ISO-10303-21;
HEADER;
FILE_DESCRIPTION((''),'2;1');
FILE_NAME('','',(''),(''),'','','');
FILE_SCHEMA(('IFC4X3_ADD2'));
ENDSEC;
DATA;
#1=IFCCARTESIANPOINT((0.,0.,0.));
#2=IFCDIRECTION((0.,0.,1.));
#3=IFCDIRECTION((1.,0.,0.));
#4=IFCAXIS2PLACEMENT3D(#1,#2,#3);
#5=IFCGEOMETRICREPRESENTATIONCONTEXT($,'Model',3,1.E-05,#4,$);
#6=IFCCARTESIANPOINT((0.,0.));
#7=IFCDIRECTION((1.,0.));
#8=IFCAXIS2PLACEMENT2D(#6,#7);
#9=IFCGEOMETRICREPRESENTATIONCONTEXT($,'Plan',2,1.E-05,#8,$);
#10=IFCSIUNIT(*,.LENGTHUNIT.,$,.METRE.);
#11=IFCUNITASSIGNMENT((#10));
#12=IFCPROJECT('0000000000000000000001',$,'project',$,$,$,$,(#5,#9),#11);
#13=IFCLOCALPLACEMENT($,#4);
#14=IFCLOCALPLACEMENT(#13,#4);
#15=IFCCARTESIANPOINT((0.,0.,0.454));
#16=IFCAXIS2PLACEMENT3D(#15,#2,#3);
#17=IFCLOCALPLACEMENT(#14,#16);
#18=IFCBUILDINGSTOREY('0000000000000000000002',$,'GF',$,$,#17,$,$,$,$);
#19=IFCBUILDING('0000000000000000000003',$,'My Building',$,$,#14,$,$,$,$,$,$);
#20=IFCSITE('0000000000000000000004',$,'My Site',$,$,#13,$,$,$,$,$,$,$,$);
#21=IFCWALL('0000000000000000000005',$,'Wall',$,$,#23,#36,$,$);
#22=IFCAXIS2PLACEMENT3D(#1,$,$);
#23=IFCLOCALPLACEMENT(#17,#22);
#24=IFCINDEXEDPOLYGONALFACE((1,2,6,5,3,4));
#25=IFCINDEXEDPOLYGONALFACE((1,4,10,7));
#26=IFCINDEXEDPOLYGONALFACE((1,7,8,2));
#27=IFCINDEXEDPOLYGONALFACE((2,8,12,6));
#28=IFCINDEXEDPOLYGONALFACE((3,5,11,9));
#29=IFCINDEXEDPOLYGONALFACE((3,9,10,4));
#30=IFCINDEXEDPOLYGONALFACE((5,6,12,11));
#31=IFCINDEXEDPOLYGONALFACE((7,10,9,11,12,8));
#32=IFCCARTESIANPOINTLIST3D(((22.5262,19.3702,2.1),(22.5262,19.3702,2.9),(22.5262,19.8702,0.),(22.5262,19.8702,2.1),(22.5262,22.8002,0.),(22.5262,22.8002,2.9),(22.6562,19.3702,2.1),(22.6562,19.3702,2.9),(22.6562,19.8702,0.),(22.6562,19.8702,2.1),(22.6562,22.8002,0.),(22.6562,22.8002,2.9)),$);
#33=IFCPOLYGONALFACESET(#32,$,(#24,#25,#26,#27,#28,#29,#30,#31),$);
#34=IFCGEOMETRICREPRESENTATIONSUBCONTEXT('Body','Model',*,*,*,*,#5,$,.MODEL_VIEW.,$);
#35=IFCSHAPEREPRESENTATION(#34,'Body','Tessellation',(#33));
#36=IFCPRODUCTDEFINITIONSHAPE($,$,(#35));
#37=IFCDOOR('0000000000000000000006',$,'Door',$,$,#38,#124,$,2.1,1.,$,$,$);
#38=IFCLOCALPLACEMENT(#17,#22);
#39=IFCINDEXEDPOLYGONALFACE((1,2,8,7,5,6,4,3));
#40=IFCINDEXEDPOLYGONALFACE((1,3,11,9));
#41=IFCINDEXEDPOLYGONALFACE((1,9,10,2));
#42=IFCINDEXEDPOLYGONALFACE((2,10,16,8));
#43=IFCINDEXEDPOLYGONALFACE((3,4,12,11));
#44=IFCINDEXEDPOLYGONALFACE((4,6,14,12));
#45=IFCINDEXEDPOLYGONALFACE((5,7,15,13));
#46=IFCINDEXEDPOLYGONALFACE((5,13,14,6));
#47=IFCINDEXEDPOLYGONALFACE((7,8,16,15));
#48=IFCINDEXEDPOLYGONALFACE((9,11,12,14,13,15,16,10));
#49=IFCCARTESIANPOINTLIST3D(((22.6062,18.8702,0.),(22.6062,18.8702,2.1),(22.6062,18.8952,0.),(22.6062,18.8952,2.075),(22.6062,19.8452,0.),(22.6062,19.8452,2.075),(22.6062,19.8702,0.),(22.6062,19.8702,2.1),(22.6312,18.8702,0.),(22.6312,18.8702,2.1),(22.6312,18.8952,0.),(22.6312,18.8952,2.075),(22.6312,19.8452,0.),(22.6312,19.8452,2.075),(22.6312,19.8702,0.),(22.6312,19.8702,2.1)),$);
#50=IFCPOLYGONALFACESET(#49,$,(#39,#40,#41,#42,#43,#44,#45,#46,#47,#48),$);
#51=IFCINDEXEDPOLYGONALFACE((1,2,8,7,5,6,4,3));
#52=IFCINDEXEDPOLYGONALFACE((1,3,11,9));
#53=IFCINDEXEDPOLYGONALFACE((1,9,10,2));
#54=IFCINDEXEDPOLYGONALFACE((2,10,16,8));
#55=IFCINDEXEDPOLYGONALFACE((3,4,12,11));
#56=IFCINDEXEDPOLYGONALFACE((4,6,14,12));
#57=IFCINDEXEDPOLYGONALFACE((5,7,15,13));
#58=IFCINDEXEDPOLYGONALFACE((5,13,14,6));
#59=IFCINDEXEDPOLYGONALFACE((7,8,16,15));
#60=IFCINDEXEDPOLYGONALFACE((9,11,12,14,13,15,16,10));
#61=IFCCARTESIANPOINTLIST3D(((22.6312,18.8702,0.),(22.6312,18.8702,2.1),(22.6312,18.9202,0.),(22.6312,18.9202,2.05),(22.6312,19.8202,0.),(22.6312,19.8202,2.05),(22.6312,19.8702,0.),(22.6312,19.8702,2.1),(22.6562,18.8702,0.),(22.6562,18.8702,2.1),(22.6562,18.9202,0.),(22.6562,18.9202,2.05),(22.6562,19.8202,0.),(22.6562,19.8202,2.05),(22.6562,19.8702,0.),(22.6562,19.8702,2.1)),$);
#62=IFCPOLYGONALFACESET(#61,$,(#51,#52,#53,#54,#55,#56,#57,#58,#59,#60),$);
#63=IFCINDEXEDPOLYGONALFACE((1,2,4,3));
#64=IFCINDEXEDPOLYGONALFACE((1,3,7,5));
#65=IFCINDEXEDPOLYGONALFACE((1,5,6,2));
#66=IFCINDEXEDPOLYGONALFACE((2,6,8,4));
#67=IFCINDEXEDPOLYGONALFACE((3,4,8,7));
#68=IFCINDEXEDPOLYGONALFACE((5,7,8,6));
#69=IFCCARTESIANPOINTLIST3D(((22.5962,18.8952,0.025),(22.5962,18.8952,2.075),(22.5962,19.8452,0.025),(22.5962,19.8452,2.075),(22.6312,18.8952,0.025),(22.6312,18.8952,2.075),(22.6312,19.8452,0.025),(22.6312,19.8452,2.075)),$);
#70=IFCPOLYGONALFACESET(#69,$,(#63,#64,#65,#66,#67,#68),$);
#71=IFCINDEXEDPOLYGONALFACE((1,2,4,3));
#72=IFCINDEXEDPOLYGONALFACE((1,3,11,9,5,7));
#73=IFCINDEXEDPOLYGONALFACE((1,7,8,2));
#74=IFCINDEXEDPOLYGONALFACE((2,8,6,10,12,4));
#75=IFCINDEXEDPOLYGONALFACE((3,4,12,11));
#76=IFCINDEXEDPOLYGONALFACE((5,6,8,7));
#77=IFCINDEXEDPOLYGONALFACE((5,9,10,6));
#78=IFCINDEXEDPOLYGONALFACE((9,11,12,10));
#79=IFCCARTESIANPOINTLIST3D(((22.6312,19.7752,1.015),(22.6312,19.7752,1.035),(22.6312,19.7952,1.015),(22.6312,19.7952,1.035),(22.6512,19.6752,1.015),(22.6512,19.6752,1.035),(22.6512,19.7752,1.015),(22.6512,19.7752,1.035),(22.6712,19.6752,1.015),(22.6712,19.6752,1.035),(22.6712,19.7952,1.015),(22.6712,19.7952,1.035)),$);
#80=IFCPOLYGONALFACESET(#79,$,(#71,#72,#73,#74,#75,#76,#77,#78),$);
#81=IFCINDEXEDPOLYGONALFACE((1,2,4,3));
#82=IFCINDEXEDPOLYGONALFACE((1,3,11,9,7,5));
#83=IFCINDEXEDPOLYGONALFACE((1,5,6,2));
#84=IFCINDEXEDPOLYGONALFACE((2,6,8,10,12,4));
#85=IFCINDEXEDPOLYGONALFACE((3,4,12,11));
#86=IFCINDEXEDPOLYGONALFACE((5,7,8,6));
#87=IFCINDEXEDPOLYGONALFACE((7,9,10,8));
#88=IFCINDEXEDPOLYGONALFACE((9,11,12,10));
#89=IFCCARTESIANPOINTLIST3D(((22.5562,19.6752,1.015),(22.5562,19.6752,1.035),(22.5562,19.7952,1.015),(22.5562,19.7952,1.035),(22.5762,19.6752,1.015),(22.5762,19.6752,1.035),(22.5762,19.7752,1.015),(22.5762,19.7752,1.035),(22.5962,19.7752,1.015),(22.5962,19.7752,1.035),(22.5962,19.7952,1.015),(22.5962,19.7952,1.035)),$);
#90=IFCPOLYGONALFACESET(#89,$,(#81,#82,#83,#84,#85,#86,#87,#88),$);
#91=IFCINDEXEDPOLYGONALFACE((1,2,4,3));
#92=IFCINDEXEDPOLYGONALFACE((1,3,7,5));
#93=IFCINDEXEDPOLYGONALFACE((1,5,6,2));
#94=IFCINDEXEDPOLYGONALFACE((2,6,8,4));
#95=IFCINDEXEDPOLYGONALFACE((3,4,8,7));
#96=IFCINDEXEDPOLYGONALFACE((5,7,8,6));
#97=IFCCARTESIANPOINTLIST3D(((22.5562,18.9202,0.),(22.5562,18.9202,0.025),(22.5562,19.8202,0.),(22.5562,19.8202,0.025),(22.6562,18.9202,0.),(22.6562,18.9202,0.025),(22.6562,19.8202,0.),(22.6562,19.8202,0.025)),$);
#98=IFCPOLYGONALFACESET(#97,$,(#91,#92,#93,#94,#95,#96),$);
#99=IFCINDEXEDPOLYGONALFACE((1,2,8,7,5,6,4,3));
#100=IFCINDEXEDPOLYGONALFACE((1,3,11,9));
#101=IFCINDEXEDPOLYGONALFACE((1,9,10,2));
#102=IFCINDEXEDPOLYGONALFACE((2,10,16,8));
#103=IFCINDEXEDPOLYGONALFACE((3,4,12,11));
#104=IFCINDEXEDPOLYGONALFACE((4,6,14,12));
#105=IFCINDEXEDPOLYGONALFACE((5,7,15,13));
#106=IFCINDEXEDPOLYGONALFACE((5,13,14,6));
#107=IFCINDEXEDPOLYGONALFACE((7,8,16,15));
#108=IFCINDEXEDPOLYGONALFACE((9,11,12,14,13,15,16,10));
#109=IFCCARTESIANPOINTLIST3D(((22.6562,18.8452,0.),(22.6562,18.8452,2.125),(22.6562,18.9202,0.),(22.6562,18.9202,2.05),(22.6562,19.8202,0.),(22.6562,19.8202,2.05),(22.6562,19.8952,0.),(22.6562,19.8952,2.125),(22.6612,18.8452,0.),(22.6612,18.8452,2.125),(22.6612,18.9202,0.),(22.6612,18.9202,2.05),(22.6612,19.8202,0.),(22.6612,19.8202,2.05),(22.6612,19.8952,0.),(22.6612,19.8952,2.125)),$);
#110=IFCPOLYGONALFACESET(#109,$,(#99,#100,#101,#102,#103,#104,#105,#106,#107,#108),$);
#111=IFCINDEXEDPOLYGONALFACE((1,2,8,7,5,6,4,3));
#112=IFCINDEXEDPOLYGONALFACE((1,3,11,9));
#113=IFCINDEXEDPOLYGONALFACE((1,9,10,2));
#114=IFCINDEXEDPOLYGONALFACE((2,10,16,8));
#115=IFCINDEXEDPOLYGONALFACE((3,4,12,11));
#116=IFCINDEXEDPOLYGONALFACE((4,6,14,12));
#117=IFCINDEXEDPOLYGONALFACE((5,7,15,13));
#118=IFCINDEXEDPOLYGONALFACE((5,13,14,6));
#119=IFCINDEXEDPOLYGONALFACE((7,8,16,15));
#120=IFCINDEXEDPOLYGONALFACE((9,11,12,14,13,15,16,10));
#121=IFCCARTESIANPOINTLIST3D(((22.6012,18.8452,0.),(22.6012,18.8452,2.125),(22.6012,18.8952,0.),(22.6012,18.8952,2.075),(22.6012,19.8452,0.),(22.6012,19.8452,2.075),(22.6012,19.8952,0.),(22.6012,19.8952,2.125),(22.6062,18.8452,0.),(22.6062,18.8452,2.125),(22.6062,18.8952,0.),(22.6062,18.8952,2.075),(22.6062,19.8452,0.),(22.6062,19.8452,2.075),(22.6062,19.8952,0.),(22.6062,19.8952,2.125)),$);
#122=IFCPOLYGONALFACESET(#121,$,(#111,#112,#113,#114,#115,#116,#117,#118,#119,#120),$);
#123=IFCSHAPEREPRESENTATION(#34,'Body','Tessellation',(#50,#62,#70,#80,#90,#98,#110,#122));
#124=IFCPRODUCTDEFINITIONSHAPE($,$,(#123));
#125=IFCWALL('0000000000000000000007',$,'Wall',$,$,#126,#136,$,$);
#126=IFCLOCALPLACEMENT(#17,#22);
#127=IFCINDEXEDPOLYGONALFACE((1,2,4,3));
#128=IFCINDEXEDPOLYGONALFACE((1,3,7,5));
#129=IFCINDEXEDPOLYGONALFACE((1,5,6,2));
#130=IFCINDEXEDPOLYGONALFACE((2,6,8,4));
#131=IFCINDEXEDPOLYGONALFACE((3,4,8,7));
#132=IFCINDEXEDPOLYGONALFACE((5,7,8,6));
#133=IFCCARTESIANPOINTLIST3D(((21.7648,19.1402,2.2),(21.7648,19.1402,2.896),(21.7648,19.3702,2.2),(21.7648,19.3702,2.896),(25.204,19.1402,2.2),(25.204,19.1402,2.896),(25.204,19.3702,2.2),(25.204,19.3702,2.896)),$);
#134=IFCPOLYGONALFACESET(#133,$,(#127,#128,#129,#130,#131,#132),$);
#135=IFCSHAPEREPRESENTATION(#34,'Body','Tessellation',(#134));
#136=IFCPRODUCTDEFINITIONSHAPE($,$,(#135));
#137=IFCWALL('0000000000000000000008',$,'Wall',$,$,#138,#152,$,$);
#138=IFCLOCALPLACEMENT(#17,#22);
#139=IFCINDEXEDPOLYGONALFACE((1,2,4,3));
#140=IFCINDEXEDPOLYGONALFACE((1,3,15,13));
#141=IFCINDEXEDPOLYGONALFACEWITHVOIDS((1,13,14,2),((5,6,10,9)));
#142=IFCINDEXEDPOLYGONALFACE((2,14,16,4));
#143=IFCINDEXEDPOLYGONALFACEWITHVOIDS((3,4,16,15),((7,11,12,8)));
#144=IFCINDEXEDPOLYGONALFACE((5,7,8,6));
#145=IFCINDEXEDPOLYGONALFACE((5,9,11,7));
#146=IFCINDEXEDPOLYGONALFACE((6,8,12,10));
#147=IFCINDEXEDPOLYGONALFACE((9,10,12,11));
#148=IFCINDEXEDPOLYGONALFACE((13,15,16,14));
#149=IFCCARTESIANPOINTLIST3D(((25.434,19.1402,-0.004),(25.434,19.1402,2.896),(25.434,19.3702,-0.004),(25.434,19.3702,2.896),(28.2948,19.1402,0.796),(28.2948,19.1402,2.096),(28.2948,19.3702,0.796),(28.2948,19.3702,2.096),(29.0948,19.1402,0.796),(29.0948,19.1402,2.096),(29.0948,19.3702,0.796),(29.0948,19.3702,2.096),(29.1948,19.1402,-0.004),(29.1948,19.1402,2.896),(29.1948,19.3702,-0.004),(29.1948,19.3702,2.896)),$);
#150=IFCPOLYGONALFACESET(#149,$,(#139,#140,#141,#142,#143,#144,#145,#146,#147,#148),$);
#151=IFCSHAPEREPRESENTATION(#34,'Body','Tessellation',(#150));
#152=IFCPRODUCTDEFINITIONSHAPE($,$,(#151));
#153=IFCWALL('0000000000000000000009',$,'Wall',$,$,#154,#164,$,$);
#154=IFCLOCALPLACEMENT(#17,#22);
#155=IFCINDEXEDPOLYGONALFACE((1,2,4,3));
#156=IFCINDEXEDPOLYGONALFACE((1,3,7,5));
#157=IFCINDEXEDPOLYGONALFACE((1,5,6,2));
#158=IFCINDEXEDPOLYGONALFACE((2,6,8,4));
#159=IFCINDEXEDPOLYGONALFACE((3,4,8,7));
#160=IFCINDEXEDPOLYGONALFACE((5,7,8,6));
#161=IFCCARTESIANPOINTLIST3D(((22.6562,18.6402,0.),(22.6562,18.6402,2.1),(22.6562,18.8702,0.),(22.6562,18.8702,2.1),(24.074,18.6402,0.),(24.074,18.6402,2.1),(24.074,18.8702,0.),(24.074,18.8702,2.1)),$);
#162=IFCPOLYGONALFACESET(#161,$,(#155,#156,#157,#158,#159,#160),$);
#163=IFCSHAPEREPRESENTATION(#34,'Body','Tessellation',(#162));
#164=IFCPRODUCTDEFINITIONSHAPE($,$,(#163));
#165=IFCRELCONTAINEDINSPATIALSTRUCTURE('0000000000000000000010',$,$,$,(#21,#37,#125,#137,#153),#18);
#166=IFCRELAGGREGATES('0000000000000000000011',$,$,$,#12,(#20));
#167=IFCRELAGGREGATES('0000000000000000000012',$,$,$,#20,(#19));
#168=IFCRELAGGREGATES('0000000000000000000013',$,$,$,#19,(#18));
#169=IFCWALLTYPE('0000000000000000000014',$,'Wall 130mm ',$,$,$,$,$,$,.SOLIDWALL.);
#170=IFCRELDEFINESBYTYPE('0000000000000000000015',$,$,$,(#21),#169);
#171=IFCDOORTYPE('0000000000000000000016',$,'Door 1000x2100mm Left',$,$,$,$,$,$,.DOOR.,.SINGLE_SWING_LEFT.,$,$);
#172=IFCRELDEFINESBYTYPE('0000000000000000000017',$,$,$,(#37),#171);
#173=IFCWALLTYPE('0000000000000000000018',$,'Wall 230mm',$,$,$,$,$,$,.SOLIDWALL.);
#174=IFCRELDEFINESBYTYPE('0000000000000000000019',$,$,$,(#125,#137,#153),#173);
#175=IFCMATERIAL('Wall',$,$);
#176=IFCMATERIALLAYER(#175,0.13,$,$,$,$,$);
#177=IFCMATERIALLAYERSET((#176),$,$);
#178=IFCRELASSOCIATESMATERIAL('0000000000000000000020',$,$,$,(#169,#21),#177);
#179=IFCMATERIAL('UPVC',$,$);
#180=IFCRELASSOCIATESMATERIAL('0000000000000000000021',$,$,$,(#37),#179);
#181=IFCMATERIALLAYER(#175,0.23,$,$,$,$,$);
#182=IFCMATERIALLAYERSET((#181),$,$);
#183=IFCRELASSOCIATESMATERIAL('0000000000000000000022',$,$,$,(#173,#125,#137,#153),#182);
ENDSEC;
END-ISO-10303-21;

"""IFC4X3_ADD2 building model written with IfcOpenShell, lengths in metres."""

from ifc_helpers import new_model, entity, si_unit, frame, origin_with_axes, origin_2d_with_axis, place, context, subcontext, project, spatial, line, indexed_curve, outline, extrude, clip, halfspace, shape, source, transform, mapped, material, layer, layer_set, layer_usage, type_object, type_shapes, element, fill, save


model = new_model("IFC4X3_ADD2")

# Units and contexts
model_context = context("Model", 3, precision=1e-05, world=origin_with_axes())
plan_context = context("Plan", 2, precision=1e-05, world=origin_2d_with_axis())
body_context_1 = subcontext(model_context, "Body", "Model", "MODEL_VIEW")
body_context_2 = subcontext(plan_context, "Body", "Plan", "PLAN_VIEW")
ifc_project = project(units=[si_unit("LENGTHUNIT", "METRE")], contexts=[model_context, plan_context])

# Site, building, storey
site_placement = place(None, origin_with_axes())
site = spatial("IfcSite", under=ifc_project, at=site_placement, Name="My Site")
building_placement = place(site_placement, origin_with_axes())
building = spatial("IfcBuilding", under=site, at=building_placement, Name="My Building")
storey_placement = place(building_placement, frame((0.0, 0.0, 0.454), z_axis=(0.0, 0.0, 1.0), x_axis=(1.0, 0.0, 0.0)))
storey = spatial("IfcBuildingStorey", under=building, at=storey_placement, Name="GF")

# Shared definitions
ifc_material_1 = material(Name="Wall")
ifc_layer_1 = layer(ifc_material_1, 0.13)
ifc_layer_set_1 = layer_set([ifc_layer_1])
wall_type_1 = type_object("IfcWallType", Name="Wall 130mm ", PredefinedType="SOLIDWALL", material=ifc_layer_set_1)
ifc_material_2 = material(Name="UPVC")

# Wall, opening, door
ifc_layer_usage_1 = layer_usage(ifc_layer_set_1, "AXIS2", "POSITIVE", 0.0)
wall_1_placement = place(storey_placement, frame((22.6562, 19.3702, 0.0), z_axis=(0.0, 0.0, 1.0), x_axis=(0.000002, 1.0, 0.0)))
wall_1 = element("IfcWall", 1, at=wall_1_placement, inside=storey, type_object=wall_type_1, material=ifc_layer_usage_1, Name="Wall", context=body_context_1, shape_type="SweptSolid", body=[
    extrude(outline(indexed_curve([(0.0, 0.0), (0.0, 0.13), (3.43, 0.13), (3.43, 0.0), (0.0, 0.0)], self_intersect=False)), origin_with_axes(), (0.0, 0.0, 1.0), 2.9),
])
shared_shape_1 = source(origin_with_axes(), body_context_1, "Body", "SweptSolid", [
    extrude(outline(indexed_curve([(0.0, 0.0), (1.0, 0.0), (1.0, 2.1), (0.0, 2.1)], segments=[line(1, 2, 3, 4, 1)])), frame((0.0, -0.6, 0.0), z_axis=(0.0, -1.0, 0.0), x_axis=(1.0, 0.0, 0.0)), (0.0, 0.0, -1.0), 1.2),
])
opening_1_placement = place(wall_1_placement, frame((-0.5, 0.0, 0.0), z_axis=(0.0, 0.0, 1.0), x_axis=(1.0, 0.0, 0.0)))
opening_1 = element("IfcOpeningElement", 2, at=opening_1_placement, cuts=wall_1, PredefinedType="OPENING", context=body_context_1, shape_type="MappedRepresentation", body=[
    mapped(shared_shape_1, transform((0.0, 0.0, 0.0), x_axis=(1.0, 0.0, 0.0), y_axis=(0.0, 1.0, 0.0), z_axis=(0.0, 0.0, 1.0), scale=1.0)),
])
door_type_1 = type_object("IfcDoorType", Name="Door 1000x2100mm Left", OperationType="SINGLE_SWING_LEFT", PredefinedType="DOOR")
shared_shape_2 = source(origin_with_axes(), body_context_1, "Body", "SweptSolid", [
    extrude(outline(indexed_curve([(0.0, 0.0), (0.0, 2.1), (1.0, 2.1), (1.0, 0.0), (0.975, 0.0), (0.975, 2.075), (0.025, 2.075), (0.025, 0.0)], segments=[line(1, 2, 3, 4, 5, 6, 7, 8, 1)])), frame((0.0, 0.025, 0.0), z_axis=(0.0, -1.0, 0.0), x_axis=(1.0, 0.0, 0.0)), (0.0, 0.0, -1.0), 0.025),
    extrude(outline(indexed_curve([(0.0, 0.0), (0.0, 2.1), (1.0, 2.1), (1.0, 0.0), (0.95, 0.0), (0.95, 2.05), (0.05, 2.05), (0.05, 0.0)], segments=[line(1, 2, 3, 4, 5, 6, 7, 8, 1)])), frame((0.0, 0.0, 0.0), z_axis=(0.0, -1.0, 0.0), x_axis=(1.0, 0.0, 0.0)), (0.0, 0.0, -1.0), 0.025),
    extrude(outline(indexed_curve([(0.0, 0.0), (0.95, 0.0), (0.95, 0.035), (0.0, 0.035)], segments=[line(1, 2, 3, 4, 1)])), frame((0.025, 0.025, 0.025), z_axis=(0.0, 0.0, 1.0), x_axis=(1.0, 0.0, 0.0)), (0.0, 0.0, 1.0), 2.05),
    extrude(outline(indexed_curve([(0.0, 0.0), (0.0, -0.04), (-0.12, -0.04), (-0.12, -0.02), (-0.02, -0.02), (-0.02, 0.0)], segments=[line(1, 2, 3, 4, 5, 6, 1)])), frame((0.925, 0.025, 1.015), z_axis=(0.0, 0.0, 1.0), x_axis=(1.0, 0.0, 0.0)), (0.0, 0.0, 1.0), 0.02),
    extrude(outline(indexed_curve([(0.0, 0.0), (0.0, 0.04), (-0.12, 0.04), (-0.12, 0.02), (-0.02, 0.02), (-0.02, 0.0)], segments=[line(1, 2, 3, 4, 5, 6, 1)])), frame((0.925, 0.06, 1.015), z_axis=(0.0, 0.0, 1.0), x_axis=(1.0, 0.0, 0.0)), (0.0, 0.0, 1.0), 0.02),
    extrude(outline(indexed_curve([(0.0, 0.0), (0.9, 0.0), (0.9, 0.1), (0.0, 0.1)], segments=[line(1, 2, 3, 4, 1)])), frame((0.05, 0.0, 0.0), z_axis=(0.0, 0.0, 1.0), x_axis=(1.0, 0.0, 0.0)), (0.0, 0.0, 1.0), 0.025),
    extrude(outline(indexed_curve([(0.0, 0.0), (0.0, 2.125), (1.05, 2.125), (1.05, 0.0), (0.975, 0.0), (0.975, 2.05), (0.075, 2.05), (0.075, 0.0)], segments=[line(1, 2, 3, 4, 5, 6, 7, 8, 1)])), frame((-0.025, -0.005, 0.0), z_axis=(0.0, -1.0, 0.0), x_axis=(1.0, 0.0, 0.0)), (0.0, 0.0, -1.0), 0.005),
    extrude(outline(indexed_curve([(0.0, 0.0), (0.0, 2.125), (1.05, 2.125), (1.05, 0.0), (1.0, 0.0), (1.0, 2.075), (0.05, 2.075), (0.05, 0.0)], segments=[line(1, 2, 3, 4, 5, 6, 7, 8, 1)])), frame((-0.025, 0.05, 0.0), z_axis=(0.0, -1.0, 0.0), x_axis=(1.0, 0.0, 0.0)), (0.0, 0.0, -1.0), 0.005),
])
shared_shape_3 = source(origin_with_axes(), body_context_2, "Body", "Curve2D", [
    entity("IfcIndexedPolyCurve", entity("IfcCartesianPointList2D", [[0.0, 0.0], [0.0, 0.05], [0.025, 0.05], [0.025, 0.025], [0.05, 0.025], [0.05, 0.0]]), [entity("IfcLineIndex", [1, 2, 3, 4, 5, 6, 1])]),
    entity("IfcIndexedPolyCurve", entity("IfcCartesianPointList2D", [[1.0, 0.0], [1.0, 0.05], [0.975, 0.05], [0.975, 0.025], [0.95, 0.025], [0.95, 0.0]]), [entity("IfcLineIndex", [1, 2, 3, 4, 5, 6, 1])]),
    entity("IfcTrimmedCurve", entity("IfcEllipse", entity("IfcAxis2Placement2D", entity("IfcCartesianPoint", [0.06, 0.05]), entity("IfcDirection", [1.0, 0.0])), 0.915, 0.95), [entity("IfcCartesianPoint", [0.975, 0.05])], [entity("IfcCartesianPoint", [0.06, 1.0])], True, "CARTESIAN"),
    entity("IfcIndexedPolyCurve", entity("IfcCartesianPointList2D", [[0.025, 0.05], [0.06, 0.05], [0.06, 1.0], [0.025, 1.0]]), [entity("IfcLineIndex", [1, 2, 3, 4, 1])]),
])
type_shapes(door_type_1, [shared_shape_2, shared_shape_3])
door_1_placement = place(opening_1_placement, frame((0.0, 0.0, 0.0), z_axis=(0.0, 0.0, 1.0), x_axis=(1.0, 0.0, 0.0)))
door_1 = element("IfcDoor", 3, at=door_1_placement, inside=storey, type_object=door_type_1, material=ifc_material_2, Name="Door", OverallHeight=2.1, OverallWidth=1.0, shapes=[
    shape(body_context_1, "Body", "MappedRepresentation", [mapped(shared_shape_2, transform((0.0, 0.0, 0.0), x_axis=(1.0, 0.0, 0.0), y_axis=(0.0, 1.0, 0.0), z_axis=(0.0, 0.0, 1.0), scale=1.0))]),
    shape(body_context_2, "Body", "MappedRepresentation", [mapped(shared_shape_3, transform((0.0, 0.0, 0.0), x_axis=(1.0, 0.0, 0.0), y_axis=(0.0, 1.0, 0.0), z_axis=(0.0, 0.0, 1.0), scale=1.0))]),
])
fill(opening_1, door_1)

# Shared definitions
ifc_layer_2 = layer(ifc_material_1, 0.23)
ifc_layer_set_2 = layer_set([ifc_layer_2])
wall_type_2 = type_object("IfcWallType", Name="Wall 230mm", PredefinedType="SOLIDWALL", material=ifc_layer_set_2)
shared_shape_4 = source(origin_with_axes(), body_context_1, "Body", "SweptSolid", [
    extrude(outline(indexed_curve([(0.0, 0.0), (0.8, 0.0), (0.8, 1.3), (0.0, 1.3)], segments=[line(1, 2, 3, 4, 1)])), frame((-0.4, -0.6, 0.0), z_axis=(0.0, -1.0, 0.0), x_axis=(1.0, 0.0, 0.0)), (0.0, 0.0, -1.0), 1.2),
])

# Wall
ifc_layer_usage_2 = layer_usage(ifc_layer_set_2, "AXIS2", "POSITIVE", 0.0)
wall_2_placement = place(storey_placement, frame((25.204, 19.3702, 2.2), z_axis=(0.0, 0.0, 1.0), x_axis=(-1.0, 0.0, 0.0)))
element("IfcWall", 4, at=wall_2_placement, inside=storey, type_object=wall_type_2, material=ifc_layer_usage_2, Name="Wall", context=body_context_1, shape_type="Clipping", body=[
    clip(clip(extrude(outline(indexed_curve([(0.0, 0.0), (0.0, 0.23), (3.4392, 0.23), (3.4392, 0.0), (0.0, 0.0)], self_intersect=False)), origin_with_axes(), (0.0, 0.0, 1.0), 6.25), halfspace(frame((0.0, 0.0, 3.596), z_axis=(0.0, 0.0, 1.0), x_axis=(-1.0, 0.0, 0.0)), False)), halfspace(frame((0.0, 0.0, 0.696), z_axis=(0.0, 0.0, 1.0), x_axis=(-1.0, 0.0, 0.0)), False)),
])

# Wall, opening
ifc_layer_usage_3 = layer_usage(ifc_layer_set_2, "AXIS2", "POSITIVE", 0.0)
wall_3_placement = place(storey_placement, frame((29.1948, 19.3702, -0.004), z_axis=(0.0, 0.0, 1.0), x_axis=(-1.0, 0.0, 0.0)))
wall_3 = element("IfcWall", 5, at=wall_3_placement, inside=storey, type_object=wall_type_2, material=ifc_layer_usage_3, Name="Wall", context=body_context_1, shape_type="SweptSolid", body=[
    extrude(outline(indexed_curve([(0.0, 0.0), (0.0, 0.23), (3.7608, 0.23), (3.7608, 0.0), (0.0, 0.0)], self_intersect=False)), origin_with_axes(), (0.0, 0.0, 1.0), 2.9),
])
opening_2_placement = place(wall_3_placement, frame((0.5, 0.16, 0.8), z_axis=(0.0, 0.0, 1.0), x_axis=(1.0, 0.0, 0.0)))
element("IfcOpeningElement", 6, at=opening_2_placement, cuts=wall_3, PredefinedType="OPENING", context=body_context_1, shape_type="MappedRepresentation", body=[
    mapped(shared_shape_4, transform((0.0, 0.0, 0.0), x_axis=(1.0, 0.0, 0.0), y_axis=(0.0, 1.0, 0.0), z_axis=(0.0, 0.0, 1.0), scale=1.0)),
])

# Wall
ifc_layer_usage_4 = layer_usage(ifc_layer_set_2, "AXIS2", "POSITIVE", 0.0)
wall_4_placement = place(storey_placement, frame((24.074, 18.8702, 0.0), z_axis=(0.0, 0.0, 1.0), x_axis=(-1.0, 0.0, 0.0)))
element("IfcWall", 7, at=wall_4_placement, inside=storey, type_object=wall_type_2, material=ifc_layer_usage_4, Name="Wall", context=body_context_1, shape_type="Clipping", body=[
    clip(extrude(outline(indexed_curve([(0.0, 0.0), (0.0, 0.23), (1.4178, 0.23), (1.4178, 0.0), (0.0, 0.0)], self_intersect=False)), origin_with_axes(), (0.0, 0.0, 1.0), 2.554), halfspace(frame((0.0, 0.0, 2.1), z_axis=(0.0, 0.0, 1.0), x_axis=(-1.0, 0.0, 0.0)), False)),
])

save(model, "model.ifc")
